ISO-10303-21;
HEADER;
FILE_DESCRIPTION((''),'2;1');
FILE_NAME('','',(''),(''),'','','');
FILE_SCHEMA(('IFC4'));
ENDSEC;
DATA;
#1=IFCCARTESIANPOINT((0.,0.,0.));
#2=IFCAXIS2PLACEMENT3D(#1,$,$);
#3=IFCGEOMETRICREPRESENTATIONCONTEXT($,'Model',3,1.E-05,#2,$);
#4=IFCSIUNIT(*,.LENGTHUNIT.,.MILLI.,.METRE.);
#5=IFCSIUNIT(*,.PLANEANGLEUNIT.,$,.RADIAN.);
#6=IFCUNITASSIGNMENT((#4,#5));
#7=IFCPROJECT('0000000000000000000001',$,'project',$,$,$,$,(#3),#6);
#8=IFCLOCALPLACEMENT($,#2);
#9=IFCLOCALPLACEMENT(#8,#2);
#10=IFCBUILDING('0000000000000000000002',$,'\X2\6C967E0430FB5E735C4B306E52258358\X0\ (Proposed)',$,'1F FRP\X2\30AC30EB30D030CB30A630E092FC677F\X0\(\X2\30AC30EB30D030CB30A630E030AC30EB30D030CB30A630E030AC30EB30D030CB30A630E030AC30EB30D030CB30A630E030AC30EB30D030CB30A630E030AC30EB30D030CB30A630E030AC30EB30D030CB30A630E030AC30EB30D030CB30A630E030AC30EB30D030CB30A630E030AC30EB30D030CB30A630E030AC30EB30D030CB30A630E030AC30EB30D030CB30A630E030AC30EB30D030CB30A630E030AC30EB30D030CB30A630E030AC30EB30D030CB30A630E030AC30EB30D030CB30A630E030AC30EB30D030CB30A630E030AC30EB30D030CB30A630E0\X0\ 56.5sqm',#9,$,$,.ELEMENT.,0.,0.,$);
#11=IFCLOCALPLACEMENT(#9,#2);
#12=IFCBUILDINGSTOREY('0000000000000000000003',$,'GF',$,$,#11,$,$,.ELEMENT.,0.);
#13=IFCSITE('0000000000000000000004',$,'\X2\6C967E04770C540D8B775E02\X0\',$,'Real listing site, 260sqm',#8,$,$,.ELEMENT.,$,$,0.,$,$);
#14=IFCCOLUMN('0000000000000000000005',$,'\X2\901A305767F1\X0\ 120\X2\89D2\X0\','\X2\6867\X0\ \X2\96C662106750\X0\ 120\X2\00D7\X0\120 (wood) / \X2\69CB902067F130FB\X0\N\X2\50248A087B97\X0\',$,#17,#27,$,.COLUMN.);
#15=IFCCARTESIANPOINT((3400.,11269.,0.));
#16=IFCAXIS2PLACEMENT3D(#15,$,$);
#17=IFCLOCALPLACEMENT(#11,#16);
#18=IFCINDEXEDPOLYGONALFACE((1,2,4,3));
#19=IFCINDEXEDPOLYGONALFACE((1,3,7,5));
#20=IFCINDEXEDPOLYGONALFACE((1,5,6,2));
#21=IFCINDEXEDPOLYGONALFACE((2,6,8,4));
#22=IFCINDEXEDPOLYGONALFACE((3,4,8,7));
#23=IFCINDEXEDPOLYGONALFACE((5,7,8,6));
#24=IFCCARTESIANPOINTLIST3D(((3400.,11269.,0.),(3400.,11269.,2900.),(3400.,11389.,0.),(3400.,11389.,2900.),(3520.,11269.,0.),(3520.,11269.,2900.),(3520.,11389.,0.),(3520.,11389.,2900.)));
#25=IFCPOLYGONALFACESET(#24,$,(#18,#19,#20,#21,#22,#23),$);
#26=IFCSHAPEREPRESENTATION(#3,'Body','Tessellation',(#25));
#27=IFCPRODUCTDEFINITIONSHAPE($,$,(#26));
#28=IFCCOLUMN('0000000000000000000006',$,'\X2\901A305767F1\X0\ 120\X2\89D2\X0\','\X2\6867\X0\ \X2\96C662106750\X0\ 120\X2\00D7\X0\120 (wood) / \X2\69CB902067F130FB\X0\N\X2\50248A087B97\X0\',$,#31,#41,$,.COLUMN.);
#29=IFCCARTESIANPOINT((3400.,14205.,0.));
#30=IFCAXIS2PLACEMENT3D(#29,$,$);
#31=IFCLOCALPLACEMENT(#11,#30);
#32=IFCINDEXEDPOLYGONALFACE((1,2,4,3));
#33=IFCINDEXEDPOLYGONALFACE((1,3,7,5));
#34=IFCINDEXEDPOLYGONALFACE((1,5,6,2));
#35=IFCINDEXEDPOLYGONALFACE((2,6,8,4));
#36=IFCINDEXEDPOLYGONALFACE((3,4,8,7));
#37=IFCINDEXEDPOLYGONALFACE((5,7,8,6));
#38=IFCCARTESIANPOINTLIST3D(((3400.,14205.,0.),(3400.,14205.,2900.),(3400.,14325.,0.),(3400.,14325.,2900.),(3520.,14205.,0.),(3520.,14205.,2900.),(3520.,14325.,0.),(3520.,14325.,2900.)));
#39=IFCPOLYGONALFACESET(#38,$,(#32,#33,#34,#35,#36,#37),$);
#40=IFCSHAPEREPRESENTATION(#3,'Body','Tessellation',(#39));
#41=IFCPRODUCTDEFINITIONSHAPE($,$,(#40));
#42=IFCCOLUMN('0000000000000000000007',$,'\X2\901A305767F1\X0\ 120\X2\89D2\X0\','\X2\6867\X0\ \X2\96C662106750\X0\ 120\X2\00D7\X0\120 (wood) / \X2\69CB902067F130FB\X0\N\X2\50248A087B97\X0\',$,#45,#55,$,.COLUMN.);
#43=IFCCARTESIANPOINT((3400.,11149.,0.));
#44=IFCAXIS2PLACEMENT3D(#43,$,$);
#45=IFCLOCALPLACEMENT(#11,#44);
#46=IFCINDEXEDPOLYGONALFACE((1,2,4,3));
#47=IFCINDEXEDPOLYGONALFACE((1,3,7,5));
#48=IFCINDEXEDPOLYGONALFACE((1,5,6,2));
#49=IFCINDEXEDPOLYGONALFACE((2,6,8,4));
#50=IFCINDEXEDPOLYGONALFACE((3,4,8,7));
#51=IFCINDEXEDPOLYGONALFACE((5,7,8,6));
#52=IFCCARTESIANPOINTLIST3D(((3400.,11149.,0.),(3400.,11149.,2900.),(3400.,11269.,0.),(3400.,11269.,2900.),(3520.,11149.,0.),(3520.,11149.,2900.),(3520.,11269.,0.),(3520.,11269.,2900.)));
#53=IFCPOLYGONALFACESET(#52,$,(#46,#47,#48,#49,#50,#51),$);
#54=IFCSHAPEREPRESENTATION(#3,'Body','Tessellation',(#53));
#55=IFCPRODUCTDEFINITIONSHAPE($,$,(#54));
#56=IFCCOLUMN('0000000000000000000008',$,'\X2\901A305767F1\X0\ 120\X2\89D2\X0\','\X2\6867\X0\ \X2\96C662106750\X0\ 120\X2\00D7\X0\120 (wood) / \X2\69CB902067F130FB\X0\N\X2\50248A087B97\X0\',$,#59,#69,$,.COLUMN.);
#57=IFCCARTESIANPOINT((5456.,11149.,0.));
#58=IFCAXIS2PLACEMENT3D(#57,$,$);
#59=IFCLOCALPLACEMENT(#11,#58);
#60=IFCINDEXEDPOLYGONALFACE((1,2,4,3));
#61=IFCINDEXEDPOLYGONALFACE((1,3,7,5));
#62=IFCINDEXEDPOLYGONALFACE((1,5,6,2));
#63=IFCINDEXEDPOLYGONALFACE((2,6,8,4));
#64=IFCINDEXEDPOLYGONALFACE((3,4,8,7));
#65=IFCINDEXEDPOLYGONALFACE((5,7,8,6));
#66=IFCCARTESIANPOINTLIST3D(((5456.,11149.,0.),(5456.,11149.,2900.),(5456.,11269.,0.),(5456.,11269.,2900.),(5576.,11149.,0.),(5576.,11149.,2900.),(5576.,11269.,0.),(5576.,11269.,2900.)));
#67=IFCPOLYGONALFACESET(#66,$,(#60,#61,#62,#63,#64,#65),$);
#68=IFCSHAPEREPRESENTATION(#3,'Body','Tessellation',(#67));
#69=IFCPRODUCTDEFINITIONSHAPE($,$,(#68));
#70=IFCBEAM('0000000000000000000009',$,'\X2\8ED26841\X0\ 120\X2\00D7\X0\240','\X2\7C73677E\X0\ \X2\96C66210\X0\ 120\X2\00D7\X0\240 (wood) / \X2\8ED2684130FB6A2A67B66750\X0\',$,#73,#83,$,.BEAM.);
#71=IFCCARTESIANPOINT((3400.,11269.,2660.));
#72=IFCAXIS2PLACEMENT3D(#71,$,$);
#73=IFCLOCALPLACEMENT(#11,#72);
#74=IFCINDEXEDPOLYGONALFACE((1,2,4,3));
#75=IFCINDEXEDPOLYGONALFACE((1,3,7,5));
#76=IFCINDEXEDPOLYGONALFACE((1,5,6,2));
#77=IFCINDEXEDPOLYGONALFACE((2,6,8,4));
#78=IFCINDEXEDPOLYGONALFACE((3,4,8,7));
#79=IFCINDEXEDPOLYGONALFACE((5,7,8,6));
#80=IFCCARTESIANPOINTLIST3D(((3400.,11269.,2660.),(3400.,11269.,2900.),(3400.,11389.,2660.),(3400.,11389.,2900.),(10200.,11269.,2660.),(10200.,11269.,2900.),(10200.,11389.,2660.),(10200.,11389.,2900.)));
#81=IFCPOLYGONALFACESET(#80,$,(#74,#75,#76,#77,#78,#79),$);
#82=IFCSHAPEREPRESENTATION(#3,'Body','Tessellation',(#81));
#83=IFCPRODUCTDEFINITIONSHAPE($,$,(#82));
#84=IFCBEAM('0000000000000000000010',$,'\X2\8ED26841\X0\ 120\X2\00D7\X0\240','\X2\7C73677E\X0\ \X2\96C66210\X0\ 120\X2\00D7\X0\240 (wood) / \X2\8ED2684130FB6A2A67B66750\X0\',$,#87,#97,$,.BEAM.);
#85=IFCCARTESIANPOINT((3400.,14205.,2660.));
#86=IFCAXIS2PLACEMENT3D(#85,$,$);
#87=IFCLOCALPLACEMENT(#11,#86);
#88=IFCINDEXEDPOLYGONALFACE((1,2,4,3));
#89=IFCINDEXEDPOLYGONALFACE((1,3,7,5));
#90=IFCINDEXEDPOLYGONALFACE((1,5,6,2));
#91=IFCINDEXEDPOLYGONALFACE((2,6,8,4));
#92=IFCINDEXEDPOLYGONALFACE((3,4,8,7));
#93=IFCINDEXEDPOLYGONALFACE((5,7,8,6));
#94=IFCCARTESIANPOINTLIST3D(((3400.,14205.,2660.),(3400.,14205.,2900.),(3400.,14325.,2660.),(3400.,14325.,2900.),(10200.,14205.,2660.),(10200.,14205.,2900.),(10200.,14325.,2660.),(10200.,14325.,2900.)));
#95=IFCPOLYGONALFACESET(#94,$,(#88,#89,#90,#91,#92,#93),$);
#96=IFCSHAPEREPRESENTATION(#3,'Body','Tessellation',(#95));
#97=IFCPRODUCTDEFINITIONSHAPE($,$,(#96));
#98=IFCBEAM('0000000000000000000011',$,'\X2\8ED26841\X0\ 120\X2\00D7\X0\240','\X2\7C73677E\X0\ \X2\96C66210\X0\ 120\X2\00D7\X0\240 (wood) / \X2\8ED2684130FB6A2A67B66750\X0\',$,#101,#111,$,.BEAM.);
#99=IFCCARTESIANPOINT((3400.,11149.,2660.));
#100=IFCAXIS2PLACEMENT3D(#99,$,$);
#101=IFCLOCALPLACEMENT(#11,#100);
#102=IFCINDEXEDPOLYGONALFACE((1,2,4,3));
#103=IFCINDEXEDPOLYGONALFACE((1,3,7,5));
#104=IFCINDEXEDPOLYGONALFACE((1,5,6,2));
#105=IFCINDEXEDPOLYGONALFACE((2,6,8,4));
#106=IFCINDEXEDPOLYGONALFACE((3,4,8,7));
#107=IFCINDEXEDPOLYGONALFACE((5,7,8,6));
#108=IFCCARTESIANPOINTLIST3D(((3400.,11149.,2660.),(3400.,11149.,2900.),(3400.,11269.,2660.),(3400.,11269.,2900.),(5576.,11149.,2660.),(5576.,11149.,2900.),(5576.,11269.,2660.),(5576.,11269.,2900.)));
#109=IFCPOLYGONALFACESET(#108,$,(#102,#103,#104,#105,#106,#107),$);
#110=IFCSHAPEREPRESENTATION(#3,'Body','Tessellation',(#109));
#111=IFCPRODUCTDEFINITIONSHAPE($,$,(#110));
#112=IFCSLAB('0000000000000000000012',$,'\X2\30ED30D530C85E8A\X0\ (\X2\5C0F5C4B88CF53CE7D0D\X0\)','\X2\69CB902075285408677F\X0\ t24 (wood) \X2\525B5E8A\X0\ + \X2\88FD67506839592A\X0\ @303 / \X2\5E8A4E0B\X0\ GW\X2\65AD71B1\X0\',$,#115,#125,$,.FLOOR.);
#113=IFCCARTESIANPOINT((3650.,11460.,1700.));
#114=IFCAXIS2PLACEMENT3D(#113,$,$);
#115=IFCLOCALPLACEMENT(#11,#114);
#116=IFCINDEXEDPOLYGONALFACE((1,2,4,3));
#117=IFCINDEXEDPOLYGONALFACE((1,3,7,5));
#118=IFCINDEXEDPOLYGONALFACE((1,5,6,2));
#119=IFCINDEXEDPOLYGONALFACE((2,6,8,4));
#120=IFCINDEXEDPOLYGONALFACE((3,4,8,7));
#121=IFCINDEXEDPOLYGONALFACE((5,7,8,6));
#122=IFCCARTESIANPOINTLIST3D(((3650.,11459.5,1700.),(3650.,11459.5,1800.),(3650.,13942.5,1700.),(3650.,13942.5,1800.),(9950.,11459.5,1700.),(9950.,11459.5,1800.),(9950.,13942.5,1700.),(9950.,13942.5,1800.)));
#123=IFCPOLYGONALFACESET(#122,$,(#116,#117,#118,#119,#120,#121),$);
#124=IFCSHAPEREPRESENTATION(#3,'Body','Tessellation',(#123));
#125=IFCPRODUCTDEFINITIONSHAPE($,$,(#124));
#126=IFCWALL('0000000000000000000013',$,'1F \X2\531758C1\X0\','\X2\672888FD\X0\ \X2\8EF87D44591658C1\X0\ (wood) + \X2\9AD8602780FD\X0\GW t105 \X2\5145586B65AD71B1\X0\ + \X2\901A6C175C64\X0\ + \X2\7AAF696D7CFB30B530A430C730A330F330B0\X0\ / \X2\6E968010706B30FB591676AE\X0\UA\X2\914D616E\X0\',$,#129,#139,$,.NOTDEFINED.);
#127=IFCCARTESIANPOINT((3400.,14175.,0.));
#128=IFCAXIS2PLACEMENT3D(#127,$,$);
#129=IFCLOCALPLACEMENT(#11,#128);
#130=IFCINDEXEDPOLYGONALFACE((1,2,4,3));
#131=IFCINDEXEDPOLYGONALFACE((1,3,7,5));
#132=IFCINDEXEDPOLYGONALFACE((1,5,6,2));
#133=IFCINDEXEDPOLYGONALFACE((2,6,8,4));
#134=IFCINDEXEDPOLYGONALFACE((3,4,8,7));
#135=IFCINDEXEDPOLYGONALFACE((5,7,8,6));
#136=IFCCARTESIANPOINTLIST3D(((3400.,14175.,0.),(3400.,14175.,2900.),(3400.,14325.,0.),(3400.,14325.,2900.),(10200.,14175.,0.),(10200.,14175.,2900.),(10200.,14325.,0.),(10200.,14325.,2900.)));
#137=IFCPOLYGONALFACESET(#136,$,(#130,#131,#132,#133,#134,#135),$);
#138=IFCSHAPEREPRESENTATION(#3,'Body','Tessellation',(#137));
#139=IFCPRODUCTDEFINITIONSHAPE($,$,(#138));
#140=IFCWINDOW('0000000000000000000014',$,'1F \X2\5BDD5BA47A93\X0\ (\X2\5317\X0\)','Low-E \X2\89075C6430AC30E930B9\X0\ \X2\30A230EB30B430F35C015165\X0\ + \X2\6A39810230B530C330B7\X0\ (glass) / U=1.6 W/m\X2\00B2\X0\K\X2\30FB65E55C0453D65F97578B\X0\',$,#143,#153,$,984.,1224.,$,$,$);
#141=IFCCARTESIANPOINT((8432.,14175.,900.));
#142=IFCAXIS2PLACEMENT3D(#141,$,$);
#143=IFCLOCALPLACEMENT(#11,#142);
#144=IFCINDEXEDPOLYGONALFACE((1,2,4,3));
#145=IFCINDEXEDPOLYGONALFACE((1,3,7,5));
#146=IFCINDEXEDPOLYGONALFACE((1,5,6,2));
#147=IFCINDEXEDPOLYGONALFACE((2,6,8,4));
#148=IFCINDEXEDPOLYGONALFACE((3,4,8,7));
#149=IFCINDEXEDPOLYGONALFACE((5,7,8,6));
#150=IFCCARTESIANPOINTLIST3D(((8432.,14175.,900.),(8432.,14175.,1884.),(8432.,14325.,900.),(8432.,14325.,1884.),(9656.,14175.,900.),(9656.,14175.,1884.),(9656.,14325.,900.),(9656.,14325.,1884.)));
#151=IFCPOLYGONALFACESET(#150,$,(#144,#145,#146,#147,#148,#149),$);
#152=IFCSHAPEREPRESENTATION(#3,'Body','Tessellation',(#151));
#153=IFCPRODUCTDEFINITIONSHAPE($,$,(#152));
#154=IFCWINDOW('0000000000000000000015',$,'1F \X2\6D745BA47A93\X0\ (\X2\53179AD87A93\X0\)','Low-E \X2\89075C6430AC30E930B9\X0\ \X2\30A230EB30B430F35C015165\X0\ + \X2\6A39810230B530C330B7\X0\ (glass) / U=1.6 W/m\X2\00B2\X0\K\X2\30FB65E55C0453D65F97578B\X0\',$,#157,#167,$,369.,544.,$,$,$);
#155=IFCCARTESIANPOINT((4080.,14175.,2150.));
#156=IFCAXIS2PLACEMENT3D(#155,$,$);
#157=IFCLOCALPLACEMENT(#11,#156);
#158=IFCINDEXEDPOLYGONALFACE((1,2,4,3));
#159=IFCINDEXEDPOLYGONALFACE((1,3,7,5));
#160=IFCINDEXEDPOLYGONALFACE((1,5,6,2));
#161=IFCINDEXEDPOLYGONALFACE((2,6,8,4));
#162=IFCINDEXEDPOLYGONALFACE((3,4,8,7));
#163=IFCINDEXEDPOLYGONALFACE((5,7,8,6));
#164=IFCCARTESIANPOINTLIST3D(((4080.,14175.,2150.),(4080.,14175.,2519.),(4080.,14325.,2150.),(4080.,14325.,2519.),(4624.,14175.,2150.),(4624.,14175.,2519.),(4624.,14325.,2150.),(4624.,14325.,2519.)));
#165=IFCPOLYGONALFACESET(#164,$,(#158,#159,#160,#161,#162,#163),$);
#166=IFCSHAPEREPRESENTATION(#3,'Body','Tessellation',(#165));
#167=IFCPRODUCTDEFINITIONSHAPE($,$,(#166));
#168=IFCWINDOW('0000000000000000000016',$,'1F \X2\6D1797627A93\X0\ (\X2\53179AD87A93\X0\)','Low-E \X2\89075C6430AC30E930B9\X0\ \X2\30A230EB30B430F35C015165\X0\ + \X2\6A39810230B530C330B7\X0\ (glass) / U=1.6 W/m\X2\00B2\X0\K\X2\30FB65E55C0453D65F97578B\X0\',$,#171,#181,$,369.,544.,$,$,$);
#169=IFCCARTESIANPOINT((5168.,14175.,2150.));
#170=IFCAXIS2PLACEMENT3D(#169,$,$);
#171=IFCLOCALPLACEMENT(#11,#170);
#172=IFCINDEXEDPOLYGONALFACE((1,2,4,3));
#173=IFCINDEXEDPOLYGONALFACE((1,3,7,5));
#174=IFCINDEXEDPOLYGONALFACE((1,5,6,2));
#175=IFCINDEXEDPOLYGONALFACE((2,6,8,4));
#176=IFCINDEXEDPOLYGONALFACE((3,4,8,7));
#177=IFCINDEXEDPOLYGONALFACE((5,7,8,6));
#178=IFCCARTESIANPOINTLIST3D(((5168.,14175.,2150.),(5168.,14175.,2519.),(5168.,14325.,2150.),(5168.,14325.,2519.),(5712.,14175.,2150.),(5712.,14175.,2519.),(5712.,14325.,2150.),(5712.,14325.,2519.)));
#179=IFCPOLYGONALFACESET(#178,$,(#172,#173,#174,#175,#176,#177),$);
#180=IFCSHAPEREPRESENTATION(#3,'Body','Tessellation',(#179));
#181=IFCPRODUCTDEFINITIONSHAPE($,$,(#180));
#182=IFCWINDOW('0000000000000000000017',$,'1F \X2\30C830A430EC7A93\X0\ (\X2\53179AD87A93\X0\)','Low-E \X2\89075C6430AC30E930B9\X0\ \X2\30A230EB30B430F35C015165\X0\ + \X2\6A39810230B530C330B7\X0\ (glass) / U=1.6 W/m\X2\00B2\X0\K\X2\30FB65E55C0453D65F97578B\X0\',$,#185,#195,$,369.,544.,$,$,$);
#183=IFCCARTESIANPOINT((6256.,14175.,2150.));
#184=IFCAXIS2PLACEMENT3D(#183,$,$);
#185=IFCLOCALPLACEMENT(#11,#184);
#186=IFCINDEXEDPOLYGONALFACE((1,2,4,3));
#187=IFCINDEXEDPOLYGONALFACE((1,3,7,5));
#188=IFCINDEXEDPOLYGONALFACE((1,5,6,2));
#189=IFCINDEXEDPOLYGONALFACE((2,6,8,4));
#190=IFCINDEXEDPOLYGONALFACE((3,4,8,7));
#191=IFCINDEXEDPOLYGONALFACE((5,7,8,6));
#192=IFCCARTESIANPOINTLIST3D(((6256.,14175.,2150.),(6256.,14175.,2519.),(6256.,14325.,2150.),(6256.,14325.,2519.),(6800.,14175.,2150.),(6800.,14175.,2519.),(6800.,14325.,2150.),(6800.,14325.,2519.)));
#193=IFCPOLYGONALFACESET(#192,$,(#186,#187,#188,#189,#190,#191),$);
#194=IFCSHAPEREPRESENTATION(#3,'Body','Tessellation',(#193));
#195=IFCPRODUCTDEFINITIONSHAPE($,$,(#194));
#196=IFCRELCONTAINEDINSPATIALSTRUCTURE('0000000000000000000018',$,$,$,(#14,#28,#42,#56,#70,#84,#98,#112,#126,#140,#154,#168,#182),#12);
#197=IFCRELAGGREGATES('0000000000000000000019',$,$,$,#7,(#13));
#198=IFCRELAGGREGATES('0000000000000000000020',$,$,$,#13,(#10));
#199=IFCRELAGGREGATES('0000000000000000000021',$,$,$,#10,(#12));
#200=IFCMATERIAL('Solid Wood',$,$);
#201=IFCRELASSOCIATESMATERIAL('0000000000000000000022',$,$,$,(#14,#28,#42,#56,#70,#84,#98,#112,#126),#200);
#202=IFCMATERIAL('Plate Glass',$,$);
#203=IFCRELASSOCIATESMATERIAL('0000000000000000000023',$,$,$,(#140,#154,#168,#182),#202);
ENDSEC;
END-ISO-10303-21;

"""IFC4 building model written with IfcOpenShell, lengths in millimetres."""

from ifc_helpers import new_model, si_unit, frame, frame_2d, origin, place, context, project, spatial, rectangle, extrude, material, element, fill, save


model = new_model("IFC4")

# Units and contexts
model_context = context("Model", 3, precision=1e-05, world=origin())
ifc_project = project(units=[si_unit("LENGTHUNIT", "METRE", prefix="MILLI"), si_unit("PLANEANGLEUNIT", "RADIAN")], contexts=[model_context])

# Site, building, storey
site_placement = place(None, origin())
site = spatial("IfcSite", under=ifc_project, at=site_placement, Name="沖縄県名護市", ObjectType="Real listing site, 260sqm", CompositionType="ELEMENT", RefElevation=0.0)
building_placement = place(site_placement, origin())
building = spatial("IfcBuilding", under=site, at=building_placement, Name="沖縄・平屋の別荘 (Proposed)", ObjectType="1F FRPガルバニウム鋼板(ガルバニウムガルバニウムガルバニウムガルバニウムガルバニウムガルバニウムガルバニウムガルバニウムガルバニウムガルバニウムガルバニウムガルバニウムガルバニウムガルバニウムガルバニウムガルバニウムガルバニウムガルバニウム 56.5sqm", CompositionType="ELEMENT", ElevationOfRefHeight=0.0, ElevationOfTerrain=0.0)
storey_placement = place(building_placement, origin())
storey = spatial("IfcBuildingStorey", under=building, at=storey_placement, Name="GF", CompositionType="ELEMENT", Elevation=0.0)

# Columns
ifc_material_1 = material(Name="Solid Wood")
column_1_placement = place(storey_placement, frame((3400.0, 11269.0, 0.0)))
element("IfcColumn", 1, at=column_1_placement, inside=storey, material=ifc_material_1, Name="通し柱 120角", Description="桧 集成材 120×120 (wood) / 構造柱・N値計算", PredefinedType="COLUMN", context=model_context, shape_type="SweptSolid", body=[
    extrude(rectangle(XDim=120.0, YDim=120.0, at=frame_2d((60.0, 60.0))), frame((3400.0, 11269.0, 0.0)), (0.0, 0.0, 1.0), 2900.0),
])
column_2_placement = place(storey_placement, frame((3400.0, 14205.0, 0.0)))
element("IfcColumn", 2, at=column_2_placement, inside=storey, material=ifc_material_1, Name="通し柱 120角", Description="桧 集成材 120×120 (wood) / 構造柱・N値計算", PredefinedType="COLUMN", context=model_context, shape_type="SweptSolid", body=[
    extrude(rectangle(XDim=120.0, YDim=120.0, at=frame_2d((60.0, 60.0))), frame((3400.0, 14205.0, 0.0)), (0.0, 0.0, 1.0), 2900.0),
])
column_3_placement = place(storey_placement, frame((3400.0, 11149.0, 0.0)))
element("IfcColumn", 3, at=column_3_placement, inside=storey, material=ifc_material_1, Name="通し柱 120角", Description="桧 集成材 120×120 (wood) / 構造柱・N値計算", PredefinedType="COLUMN", context=model_context, shape_type="SweptSolid", body=[
    extrude(rectangle(XDim=120.0, YDim=120.0, at=frame_2d((60.0, 60.0))), frame((3400.0, 11149.0, 0.0)), (0.0, 0.0, 1.0), 2900.0),
])
column_4_placement = place(storey_placement, frame((5456.0, 11149.0, 0.0)))
element("IfcColumn", 4, at=column_4_placement, inside=storey, material=ifc_material_1, Name="通し柱 120角", Description="桧 集成材 120×120 (wood) / 構造柱・N値計算", PredefinedType="COLUMN", context=model_context, shape_type="SweptSolid", body=[
    extrude(rectangle(XDim=120.0, YDim=120.0, at=frame_2d((60.0, 60.0))), frame((5456.0, 11149.0, 0.0)), (0.0, 0.0, 1.0), 2900.0),
])

# Beams
beam_1_placement = place(storey_placement, frame((3400.0, 11269.0, 2660.0)))
element("IfcBeam", 5, at=beam_1_placement, inside=storey, material=ifc_material_1, Name="軒桁 120×240", Description="米松 集成 120×240 (wood) / 軒桁・横架材", PredefinedType="BEAM", context=model_context, shape_type="SweptSolid", body=[
    extrude(rectangle(XDim=6800.0, YDim=120.0, at=frame_2d((3400.0, 60.0))), frame((3400.0, 11269.0, 2660.0)), (0.0, 0.0, 1.0), 240.0),
])
beam_2_placement = place(storey_placement, frame((3400.0, 14205.0, 2660.0)))
element("IfcBeam", 6, at=beam_2_placement, inside=storey, material=ifc_material_1, Name="軒桁 120×240", Description="米松 集成 120×240 (wood) / 軒桁・横架材", PredefinedType="BEAM", context=model_context, shape_type="SweptSolid", body=[
    extrude(rectangle(XDim=6800.0, YDim=120.0, at=frame_2d((3400.0, 60.0))), frame((3400.0, 14205.0, 2660.0)), (0.0, 0.0, 1.0), 240.0),
])
beam_3_placement = place(storey_placement, frame((3400.0, 11149.0, 2660.0)))
element("IfcBeam", 7, at=beam_3_placement, inside=storey, material=ifc_material_1, Name="軒桁 120×240", Description="米松 集成 120×240 (wood) / 軒桁・横架材", PredefinedType="BEAM", context=model_context, shape_type="SweptSolid", body=[
    extrude(rectangle(XDim=2176.0, YDim=120.0, at=frame_2d((1088.0, 60.0))), frame((3400.0, 11149.0, 2660.0)), (0.0, 0.0, 1.0), 240.0),
])

# Slab
slab_1_placement = place(storey_placement, frame((3650.0, 11460.0, 1700.0)))
element("IfcSlab", 8, at=slab_1_placement, inside=storey, material=ifc_material_1, Name="ロフト床 (小屋裏収納)", Description="構造用合板 t24 (wood) 剛床 + 製材根太 @303 / 床下 GW断熱", PredefinedType="FLOOR", context=model_context, shape_type="SweptSolid", body=[
    extrude(rectangle(XDim=6300.0, YDim=2483.0, at=frame_2d((3150.0, 1241.0))), frame((3650.0, 11460.0, 1700.0)), (0.0, 0.0, 1.0), 100.0),
])

# Wall, openings, windows
wall_1_placement = place(storey_placement, frame((3400.0, 14175.0, 0.0)))
wall_1 = element("IfcWall", 9, at=wall_1_placement, inside=storey, material=ifc_material_1, Name="1F 北壁", Description="木製 軸組外壁 (wood) + 高性能GW t105 充填断熱 + 通気層 + 窯業系サイディング / 準耐火・外皮UA配慮", PredefinedType="NOTDEFINED", context=model_context, shape_type="SweptSolid", body=[
    extrude(rectangle(XDim=6800.0, YDim=150.0, at=frame_2d((3400.0, 75.0))), frame((3400.0, 14175.0, 0.0)), (0.0, 0.0, 1.0), 2900.0),
])
opening_1_placement = place(storey_placement, frame((8432.0, 14175.0, 900.0)))
opening_1 = element("IfcOpeningElement", 10, at=opening_1_placement, cuts=wall_1, PredefinedType="NOTDEFINED", context=model_context, shape_type="SweptSolid", body=[
    extrude(rectangle(XDim=1224.0, YDim=150.0, at=frame_2d((612.0, 75.0))), frame((8432.0, 14175.0, 900.0)), (0.0, 0.0, 1.0), 984.0),
])
opening_2_placement = place(storey_placement, frame((4080.0, 14175.0, 2150.0)))
opening_2 = element("IfcOpeningElement", 11, at=opening_2_placement, cuts=wall_1, PredefinedType="NOTDEFINED", context=model_context, shape_type="SweptSolid", body=[
    extrude(rectangle(XDim=544.0, YDim=150.0, at=frame_2d((272.0, 75.0))), frame((4080.0, 14175.0, 2150.0)), (0.0, 0.0, 1.0), 369.0),
])
opening_3_placement = place(storey_placement, frame((5168.0, 14175.0, 2150.0)))
opening_3 = element("IfcOpeningElement", 12, at=opening_3_placement, cuts=wall_1, PredefinedType="NOTDEFINED", context=model_context, shape_type="SweptSolid", body=[
    extrude(rectangle(XDim=544.0, YDim=150.0, at=frame_2d((272.0, 75.0))), frame((5168.0, 14175.0, 2150.0)), (0.0, 0.0, 1.0), 369.0),
])
opening_4_placement = place(storey_placement, frame((6256.0, 14175.0, 2150.0)))
opening_4 = element("IfcOpeningElement", 13, at=opening_4_placement, cuts=wall_1, PredefinedType="NOTDEFINED", context=model_context, shape_type="SweptSolid", body=[
    extrude(rectangle(XDim=544.0, YDim=150.0, at=frame_2d((272.0, 75.0))), frame((6256.0, 14175.0, 2150.0)), (0.0, 0.0, 1.0), 369.0),
])
ifc_material_2 = material(Name="Plate Glass")
window_1_placement = place(storey_placement, frame((8432.0, 14175.0, 900.0)))
window_1 = element("IfcWindow", 14, at=window_1_placement, inside=storey, material=ifc_material_2, Name="1F 寝室窓 (北)", Description="Low-E 複層ガラス アルゴン封入 + 樹脂サッシ (glass) / U=1.6 W/m²K・日射取得型", OverallHeight=984.0, OverallWidth=1224.0, context=model_context, shape_type="SweptSolid", body=[
    extrude(rectangle(XDim=1224.0, YDim=150.0, at=frame_2d((612.0, 75.0))), frame((8432.0, 14175.0, 900.0)), (0.0, 0.0, 1.0), 984.0),
])
fill(opening_1, window_1)
window_2_placement = place(storey_placement, frame((4080.0, 14175.0, 2150.0)))
window_2 = element("IfcWindow", 15, at=window_2_placement, inside=storey, material=ifc_material_2, Name="1F 浴室窓 (北高窓)", Description="Low-E 複層ガラス アルゴン封入 + 樹脂サッシ (glass) / U=1.6 W/m²K・日射取得型", OverallHeight=369.0, OverallWidth=544.0, context=model_context, shape_type="SweptSolid", body=[
    extrude(rectangle(XDim=544.0, YDim=150.0, at=frame_2d((272.0, 75.0))), frame((4080.0, 14175.0, 2150.0)), (0.0, 0.0, 1.0), 369.0),
])
fill(opening_2, window_2)
window_3_placement = place(storey_placement, frame((5168.0, 14175.0, 2150.0)))
window_3 = element("IfcWindow", 16, at=window_3_placement, inside=storey, material=ifc_material_2, Name="1F 洗面窓 (北高窓)", Description="Low-E 複層ガラス アルゴン封入 + 樹脂サッシ (glass) / U=1.6 W/m²K・日射取得型", OverallHeight=369.0, OverallWidth=544.0, context=model_context, shape_type="SweptSolid", body=[
    extrude(rectangle(XDim=544.0, YDim=150.0, at=frame_2d((272.0, 75.0))), frame((5168.0, 14175.0, 2150.0)), (0.0, 0.0, 1.0), 369.0),
])
fill(opening_3, window_3)
window_4_placement = place(storey_placement, frame((6256.0, 14175.0, 2150.0)))
window_4 = element("IfcWindow", 17, at=window_4_placement, inside=storey, material=ifc_material_2, Name="1F トイレ窓 (北高窓)", Description="Low-E 複層ガラス アルゴン封入 + 樹脂サッシ (glass) / U=1.6 W/m²K・日射取得型", OverallHeight=369.0, OverallWidth=544.0, context=model_context, shape_type="SweptSolid", body=[
    extrude(rectangle(XDim=544.0, YDim=150.0, at=frame_2d((272.0, 75.0))), frame((6256.0, 14175.0, 2150.0)), (0.0, 0.0, 1.0), 369.0),
])
fill(opening_4, window_4)

save(model, "model.ifc")
